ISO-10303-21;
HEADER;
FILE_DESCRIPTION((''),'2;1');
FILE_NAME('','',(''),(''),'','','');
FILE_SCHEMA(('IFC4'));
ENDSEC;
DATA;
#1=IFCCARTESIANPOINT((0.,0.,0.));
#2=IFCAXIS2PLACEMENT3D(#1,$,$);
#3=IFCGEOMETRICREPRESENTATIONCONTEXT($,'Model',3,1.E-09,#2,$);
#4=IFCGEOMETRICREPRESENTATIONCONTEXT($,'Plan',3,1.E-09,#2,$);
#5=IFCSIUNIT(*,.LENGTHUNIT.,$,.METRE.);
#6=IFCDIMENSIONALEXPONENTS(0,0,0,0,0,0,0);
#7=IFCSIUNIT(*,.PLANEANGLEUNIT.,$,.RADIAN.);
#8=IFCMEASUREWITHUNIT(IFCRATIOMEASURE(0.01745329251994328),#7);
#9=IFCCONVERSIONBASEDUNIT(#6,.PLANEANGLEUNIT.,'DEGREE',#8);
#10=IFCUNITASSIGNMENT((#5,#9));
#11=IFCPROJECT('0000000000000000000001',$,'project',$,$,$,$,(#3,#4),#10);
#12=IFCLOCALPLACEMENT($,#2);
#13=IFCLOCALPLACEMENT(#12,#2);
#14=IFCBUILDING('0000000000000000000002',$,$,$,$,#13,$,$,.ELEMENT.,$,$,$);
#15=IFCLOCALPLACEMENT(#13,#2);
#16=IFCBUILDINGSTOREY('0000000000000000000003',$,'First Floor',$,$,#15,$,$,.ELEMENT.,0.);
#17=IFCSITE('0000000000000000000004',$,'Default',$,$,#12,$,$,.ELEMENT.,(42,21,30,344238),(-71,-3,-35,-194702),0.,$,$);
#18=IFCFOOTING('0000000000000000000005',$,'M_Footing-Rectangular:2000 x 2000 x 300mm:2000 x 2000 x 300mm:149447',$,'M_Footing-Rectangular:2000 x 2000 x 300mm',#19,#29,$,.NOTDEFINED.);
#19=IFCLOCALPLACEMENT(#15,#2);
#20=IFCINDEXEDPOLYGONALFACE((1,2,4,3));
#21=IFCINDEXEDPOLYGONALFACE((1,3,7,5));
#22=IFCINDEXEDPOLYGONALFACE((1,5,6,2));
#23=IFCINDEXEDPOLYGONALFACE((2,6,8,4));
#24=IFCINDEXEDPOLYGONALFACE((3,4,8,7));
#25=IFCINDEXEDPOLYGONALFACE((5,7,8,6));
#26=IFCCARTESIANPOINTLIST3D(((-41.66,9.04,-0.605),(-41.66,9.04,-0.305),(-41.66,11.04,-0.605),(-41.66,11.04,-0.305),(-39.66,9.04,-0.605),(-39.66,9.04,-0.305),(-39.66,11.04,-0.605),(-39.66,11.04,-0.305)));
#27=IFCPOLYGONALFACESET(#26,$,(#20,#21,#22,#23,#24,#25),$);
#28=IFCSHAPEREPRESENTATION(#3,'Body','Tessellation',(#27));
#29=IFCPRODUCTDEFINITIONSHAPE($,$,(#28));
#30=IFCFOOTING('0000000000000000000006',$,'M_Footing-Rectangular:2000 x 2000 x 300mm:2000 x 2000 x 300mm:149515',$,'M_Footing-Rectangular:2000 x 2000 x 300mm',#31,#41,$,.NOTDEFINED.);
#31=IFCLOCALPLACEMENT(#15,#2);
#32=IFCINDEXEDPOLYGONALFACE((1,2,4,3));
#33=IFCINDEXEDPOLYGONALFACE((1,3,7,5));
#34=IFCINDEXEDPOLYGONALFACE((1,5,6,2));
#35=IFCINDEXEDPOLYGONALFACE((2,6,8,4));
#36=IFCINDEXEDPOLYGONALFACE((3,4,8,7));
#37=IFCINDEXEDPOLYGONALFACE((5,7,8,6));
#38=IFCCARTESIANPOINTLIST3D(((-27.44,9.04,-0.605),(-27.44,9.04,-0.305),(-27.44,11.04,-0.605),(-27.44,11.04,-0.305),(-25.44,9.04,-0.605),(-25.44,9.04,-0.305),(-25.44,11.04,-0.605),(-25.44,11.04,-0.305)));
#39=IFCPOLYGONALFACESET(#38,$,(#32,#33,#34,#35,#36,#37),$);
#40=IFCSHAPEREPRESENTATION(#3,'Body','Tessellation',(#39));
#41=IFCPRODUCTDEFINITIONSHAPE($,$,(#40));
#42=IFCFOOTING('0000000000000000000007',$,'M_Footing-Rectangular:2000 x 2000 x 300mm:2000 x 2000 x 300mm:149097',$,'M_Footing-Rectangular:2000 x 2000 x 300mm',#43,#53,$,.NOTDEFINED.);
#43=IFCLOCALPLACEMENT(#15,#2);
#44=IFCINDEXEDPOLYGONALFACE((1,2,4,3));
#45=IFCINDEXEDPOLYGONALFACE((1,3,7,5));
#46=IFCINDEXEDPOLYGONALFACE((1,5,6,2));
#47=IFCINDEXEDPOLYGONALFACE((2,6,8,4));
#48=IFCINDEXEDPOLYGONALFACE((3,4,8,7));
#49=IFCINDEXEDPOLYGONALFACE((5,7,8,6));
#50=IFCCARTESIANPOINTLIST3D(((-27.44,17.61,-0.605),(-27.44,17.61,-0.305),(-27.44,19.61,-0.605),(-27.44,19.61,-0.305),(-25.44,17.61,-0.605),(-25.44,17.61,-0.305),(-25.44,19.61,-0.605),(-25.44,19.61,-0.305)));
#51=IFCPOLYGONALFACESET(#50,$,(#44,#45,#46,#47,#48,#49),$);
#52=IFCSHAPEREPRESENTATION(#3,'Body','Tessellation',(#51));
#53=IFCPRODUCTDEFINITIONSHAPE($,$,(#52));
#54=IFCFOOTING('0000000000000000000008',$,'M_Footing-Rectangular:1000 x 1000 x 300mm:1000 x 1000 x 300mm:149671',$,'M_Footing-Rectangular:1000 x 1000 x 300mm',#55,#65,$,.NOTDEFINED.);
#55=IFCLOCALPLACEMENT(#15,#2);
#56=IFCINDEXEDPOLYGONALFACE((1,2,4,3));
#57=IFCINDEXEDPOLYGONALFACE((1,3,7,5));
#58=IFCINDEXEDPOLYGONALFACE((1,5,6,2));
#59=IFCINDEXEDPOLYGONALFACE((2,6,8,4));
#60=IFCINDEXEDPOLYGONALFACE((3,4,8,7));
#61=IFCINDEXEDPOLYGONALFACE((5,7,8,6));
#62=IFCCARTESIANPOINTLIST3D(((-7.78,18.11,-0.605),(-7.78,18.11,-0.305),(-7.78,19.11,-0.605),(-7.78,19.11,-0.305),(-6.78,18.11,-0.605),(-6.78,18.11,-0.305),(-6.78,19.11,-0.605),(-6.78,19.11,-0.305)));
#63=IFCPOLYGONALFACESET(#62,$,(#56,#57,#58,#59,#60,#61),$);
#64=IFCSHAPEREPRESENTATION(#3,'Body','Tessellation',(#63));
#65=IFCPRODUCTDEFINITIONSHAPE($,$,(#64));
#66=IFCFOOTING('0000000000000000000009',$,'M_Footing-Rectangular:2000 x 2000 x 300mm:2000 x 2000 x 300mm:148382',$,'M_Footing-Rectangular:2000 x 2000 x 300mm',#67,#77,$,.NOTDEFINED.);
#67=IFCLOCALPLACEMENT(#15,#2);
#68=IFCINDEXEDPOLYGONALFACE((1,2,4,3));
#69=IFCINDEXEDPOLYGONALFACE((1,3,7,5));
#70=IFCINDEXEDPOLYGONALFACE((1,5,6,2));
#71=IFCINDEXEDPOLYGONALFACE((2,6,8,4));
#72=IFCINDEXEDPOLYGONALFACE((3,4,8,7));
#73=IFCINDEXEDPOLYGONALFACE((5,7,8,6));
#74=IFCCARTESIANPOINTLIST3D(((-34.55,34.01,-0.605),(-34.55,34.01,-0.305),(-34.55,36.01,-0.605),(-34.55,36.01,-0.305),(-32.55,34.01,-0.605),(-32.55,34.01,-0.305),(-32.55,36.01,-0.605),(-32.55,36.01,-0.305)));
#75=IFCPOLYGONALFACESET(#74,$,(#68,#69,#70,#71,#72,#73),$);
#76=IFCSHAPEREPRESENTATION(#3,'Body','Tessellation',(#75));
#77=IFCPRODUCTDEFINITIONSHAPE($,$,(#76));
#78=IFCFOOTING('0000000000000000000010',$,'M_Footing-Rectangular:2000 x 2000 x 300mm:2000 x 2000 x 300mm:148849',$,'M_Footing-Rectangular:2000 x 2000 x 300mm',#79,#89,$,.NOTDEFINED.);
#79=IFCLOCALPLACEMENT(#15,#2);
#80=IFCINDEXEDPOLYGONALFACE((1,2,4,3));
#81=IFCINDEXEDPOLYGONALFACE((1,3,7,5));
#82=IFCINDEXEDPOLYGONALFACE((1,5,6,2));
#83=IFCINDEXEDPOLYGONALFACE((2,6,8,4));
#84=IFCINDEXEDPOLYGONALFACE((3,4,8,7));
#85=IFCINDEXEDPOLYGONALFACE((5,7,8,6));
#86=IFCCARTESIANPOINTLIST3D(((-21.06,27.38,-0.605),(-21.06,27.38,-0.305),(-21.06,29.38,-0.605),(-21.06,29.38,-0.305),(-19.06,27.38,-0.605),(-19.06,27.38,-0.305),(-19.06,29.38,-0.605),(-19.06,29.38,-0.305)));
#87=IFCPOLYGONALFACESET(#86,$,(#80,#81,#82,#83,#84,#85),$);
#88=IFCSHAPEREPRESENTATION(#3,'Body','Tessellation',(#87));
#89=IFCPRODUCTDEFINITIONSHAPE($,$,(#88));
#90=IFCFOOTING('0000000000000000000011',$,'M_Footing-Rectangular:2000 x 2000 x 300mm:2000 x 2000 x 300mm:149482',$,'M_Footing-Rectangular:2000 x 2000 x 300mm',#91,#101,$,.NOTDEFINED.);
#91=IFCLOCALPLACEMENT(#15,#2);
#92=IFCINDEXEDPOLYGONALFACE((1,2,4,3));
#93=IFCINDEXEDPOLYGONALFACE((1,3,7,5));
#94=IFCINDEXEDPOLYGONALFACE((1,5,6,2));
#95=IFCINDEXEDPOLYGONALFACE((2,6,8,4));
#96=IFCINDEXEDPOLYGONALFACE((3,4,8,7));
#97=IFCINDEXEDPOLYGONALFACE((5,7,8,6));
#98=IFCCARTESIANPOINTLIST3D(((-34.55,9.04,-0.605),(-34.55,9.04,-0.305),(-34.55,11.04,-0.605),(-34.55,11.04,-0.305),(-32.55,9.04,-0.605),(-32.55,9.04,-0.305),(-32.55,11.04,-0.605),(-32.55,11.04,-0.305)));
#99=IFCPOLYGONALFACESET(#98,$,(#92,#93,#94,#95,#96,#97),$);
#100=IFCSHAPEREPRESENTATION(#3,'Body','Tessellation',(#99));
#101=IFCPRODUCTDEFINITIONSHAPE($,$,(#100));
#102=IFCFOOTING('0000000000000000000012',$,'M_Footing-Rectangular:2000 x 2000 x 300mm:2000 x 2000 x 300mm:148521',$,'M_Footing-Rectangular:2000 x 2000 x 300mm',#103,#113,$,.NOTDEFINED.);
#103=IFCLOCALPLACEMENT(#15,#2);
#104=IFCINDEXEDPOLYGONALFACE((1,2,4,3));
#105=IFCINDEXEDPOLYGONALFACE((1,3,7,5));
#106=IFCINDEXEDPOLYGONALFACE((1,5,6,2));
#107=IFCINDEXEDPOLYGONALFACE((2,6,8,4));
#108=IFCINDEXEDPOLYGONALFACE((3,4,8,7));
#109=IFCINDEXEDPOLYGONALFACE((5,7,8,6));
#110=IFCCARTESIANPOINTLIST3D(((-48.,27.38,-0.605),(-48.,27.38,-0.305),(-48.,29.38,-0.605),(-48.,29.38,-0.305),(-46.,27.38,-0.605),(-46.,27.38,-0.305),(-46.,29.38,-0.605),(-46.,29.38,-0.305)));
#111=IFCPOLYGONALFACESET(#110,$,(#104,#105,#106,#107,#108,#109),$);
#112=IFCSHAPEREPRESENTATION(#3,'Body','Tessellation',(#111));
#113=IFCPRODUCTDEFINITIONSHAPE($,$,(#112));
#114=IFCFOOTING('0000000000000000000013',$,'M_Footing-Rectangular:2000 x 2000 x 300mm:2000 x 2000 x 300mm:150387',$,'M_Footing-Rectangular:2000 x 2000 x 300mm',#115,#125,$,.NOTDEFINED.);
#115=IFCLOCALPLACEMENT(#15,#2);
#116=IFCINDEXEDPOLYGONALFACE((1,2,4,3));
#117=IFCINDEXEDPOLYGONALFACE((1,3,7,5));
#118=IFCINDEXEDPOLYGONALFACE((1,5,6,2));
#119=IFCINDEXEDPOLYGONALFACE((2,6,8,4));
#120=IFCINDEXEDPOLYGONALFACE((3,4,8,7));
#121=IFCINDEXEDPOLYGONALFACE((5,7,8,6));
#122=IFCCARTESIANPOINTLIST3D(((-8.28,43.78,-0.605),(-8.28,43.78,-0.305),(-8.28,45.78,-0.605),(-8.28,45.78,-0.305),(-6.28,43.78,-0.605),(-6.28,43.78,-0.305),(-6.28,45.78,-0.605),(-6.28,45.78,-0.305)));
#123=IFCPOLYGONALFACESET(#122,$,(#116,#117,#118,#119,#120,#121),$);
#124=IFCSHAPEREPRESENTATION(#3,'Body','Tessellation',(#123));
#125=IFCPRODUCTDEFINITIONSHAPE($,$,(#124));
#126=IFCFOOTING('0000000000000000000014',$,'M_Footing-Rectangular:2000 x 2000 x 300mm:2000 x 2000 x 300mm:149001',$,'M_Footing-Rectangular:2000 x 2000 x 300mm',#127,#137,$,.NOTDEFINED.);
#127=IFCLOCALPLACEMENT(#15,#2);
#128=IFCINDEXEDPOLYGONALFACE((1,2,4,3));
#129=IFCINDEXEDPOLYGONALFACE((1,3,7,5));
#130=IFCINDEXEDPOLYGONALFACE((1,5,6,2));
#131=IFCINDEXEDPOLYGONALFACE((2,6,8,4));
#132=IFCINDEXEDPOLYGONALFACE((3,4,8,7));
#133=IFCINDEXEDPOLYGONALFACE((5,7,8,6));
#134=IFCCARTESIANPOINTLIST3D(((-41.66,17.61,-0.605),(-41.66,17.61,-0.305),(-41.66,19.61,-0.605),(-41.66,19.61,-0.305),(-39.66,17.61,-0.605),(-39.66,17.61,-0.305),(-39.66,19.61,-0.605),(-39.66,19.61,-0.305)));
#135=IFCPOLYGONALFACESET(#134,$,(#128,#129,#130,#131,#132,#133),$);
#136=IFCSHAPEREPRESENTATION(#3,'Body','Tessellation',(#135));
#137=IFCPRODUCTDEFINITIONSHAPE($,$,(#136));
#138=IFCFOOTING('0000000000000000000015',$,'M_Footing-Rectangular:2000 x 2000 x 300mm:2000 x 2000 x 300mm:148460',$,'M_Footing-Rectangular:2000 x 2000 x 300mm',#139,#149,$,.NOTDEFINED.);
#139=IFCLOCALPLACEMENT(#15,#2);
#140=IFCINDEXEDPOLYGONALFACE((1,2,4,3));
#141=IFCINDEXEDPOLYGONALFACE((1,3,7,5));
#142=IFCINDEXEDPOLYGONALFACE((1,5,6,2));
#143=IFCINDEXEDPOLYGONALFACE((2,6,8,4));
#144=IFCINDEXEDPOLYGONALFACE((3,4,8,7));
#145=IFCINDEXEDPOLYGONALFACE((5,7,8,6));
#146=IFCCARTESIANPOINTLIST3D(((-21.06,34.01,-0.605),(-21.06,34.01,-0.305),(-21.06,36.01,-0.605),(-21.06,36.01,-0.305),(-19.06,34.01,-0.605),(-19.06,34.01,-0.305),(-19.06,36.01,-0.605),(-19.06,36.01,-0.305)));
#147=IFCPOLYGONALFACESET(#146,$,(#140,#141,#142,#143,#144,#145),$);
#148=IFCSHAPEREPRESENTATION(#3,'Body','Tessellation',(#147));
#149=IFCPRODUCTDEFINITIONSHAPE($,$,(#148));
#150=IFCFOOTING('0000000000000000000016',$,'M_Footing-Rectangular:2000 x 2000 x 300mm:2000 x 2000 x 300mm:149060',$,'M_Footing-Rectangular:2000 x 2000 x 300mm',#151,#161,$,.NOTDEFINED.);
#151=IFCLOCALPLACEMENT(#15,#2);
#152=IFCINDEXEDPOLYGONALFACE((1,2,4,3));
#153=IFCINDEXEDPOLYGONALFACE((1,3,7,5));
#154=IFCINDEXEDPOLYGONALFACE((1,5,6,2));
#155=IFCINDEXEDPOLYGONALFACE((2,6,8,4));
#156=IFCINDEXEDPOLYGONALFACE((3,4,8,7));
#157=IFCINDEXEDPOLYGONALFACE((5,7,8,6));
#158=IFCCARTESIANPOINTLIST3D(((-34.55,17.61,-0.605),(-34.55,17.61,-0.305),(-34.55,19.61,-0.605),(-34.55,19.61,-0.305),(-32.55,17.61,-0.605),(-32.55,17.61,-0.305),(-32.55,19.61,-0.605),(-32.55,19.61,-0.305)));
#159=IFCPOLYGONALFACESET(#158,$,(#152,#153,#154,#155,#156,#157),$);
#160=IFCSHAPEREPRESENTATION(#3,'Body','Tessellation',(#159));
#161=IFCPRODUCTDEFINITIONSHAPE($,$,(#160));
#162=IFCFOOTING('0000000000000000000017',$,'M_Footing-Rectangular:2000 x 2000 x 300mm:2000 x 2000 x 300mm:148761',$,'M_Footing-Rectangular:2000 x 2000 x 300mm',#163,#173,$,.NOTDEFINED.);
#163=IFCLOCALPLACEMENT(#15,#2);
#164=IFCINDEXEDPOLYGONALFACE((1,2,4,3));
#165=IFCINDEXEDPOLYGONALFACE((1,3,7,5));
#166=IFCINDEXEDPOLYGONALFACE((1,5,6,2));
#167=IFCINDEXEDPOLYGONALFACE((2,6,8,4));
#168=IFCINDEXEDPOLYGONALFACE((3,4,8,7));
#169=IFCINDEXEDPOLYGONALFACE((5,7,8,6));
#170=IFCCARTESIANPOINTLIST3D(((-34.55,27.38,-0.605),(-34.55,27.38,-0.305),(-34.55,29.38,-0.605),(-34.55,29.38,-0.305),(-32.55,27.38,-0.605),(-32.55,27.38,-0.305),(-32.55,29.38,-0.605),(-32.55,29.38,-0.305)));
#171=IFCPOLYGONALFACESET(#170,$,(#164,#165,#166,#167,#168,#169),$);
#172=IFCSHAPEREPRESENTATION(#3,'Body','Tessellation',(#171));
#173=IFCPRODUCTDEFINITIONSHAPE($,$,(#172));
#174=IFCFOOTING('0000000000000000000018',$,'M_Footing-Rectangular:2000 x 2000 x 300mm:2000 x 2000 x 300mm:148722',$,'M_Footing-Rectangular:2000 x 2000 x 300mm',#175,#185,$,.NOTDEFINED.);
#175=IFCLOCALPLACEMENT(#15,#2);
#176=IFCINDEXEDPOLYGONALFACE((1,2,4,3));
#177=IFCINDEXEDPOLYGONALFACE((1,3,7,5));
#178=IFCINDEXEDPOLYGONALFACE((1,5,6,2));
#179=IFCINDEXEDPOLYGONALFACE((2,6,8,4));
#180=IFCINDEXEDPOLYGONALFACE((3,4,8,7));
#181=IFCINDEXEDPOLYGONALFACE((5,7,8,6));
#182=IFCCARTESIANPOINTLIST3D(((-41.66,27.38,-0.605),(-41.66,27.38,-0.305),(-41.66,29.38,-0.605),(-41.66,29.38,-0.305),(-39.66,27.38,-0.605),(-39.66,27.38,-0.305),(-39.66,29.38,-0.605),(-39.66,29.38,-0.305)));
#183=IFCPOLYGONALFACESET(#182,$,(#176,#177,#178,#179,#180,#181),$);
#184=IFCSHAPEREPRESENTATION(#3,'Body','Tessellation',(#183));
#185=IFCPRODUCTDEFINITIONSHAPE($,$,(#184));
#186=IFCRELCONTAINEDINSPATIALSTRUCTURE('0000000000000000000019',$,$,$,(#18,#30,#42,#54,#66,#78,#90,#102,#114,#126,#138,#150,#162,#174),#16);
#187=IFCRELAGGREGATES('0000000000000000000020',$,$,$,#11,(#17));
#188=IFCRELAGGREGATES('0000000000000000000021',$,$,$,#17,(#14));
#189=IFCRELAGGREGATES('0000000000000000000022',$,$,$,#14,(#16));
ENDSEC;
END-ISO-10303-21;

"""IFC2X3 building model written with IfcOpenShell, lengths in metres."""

from ifc_helpers import new_model, entity, si_unit, converted_unit, frame, origin, origin_2d_with_axis, place, context, project, spatial, rectangle, extrude, element, save


model = new_model("IFC2X3")

# Units and contexts
model_context = context("Model", 3, precision=1e-09, world=origin())
plan_context = context("Plan", 3, precision=1e-09, world=origin())
ifc_project = project(units=[si_unit("LENGTHUNIT", "METRE"), converted_unit("PLANEANGLEUNIT", "DEGREE", entity("IfcRatioMeasure", 0.01745329251994328), si_unit("PLANEANGLEUNIT", "RADIAN"), dimensions=[0, 0, 0, 0, 0, 0, 0])], contexts=[model_context, plan_context])

# Site, building, storey
site_placement = place(None, origin())
site = spatial("IfcSite", under=ifc_project, at=site_placement, Name="Default", CompositionType="ELEMENT", RefLatitude=(42, 21, 30, 344238), RefLongitude=(-71, -3, -35, -194702), RefElevation=0.0)
building_placement = place(site_placement, origin())
building = spatial("IfcBuilding", under=site, at=building_placement, CompositionType="ELEMENT")
storey_placement = place(building_placement, origin())
storey = spatial("IfcBuildingStorey", under=building, at=storey_placement, Name="First Floor", CompositionType="ELEMENT", Elevation=0.0)

# Footings
footing_1_placement = place(storey_placement, origin())
element("IfcFooting", 1, at=footing_1_placement, inside=storey, Name="M_Footing-Rectangular:2000 x 2000 x 300mm:2000 x 2000 x 300mm:149447", ObjectType="M_Footing-Rectangular:2000 x 2000 x 300mm", PredefinedType="NOTDEFINED", context=model_context, shape_type="SweptSolid", body=[
    extrude(rectangle(XDim=2.0, YDim=2.0, at=origin_2d_with_axis()), frame((-40.66, 10.04, -0.605), z_axis=(0.0, 0.0, 1.0), x_axis=(-1.0, 0.0, 0.0)), (0.0, 0.0, 1.0), 0.3),
])
footing_2_placement = place(storey_placement, origin())
element("IfcFooting", 2, at=footing_2_placement, inside=storey, Name="M_Footing-Rectangular:2000 x 2000 x 300mm:2000 x 2000 x 300mm:149515", ObjectType="M_Footing-Rectangular:2000 x 2000 x 300mm", PredefinedType="NOTDEFINED", context=model_context, shape_type="SweptSolid", body=[
    extrude(rectangle(XDim=2.0, YDim=2.0, at=origin_2d_with_axis()), frame((-26.44, 10.04, -0.605), z_axis=(0.0, 0.0, 1.0), x_axis=(-1.0, 0.0, 0.0)), (0.0, 0.0, 1.0), 0.3),
])
footing_3_placement = place(storey_placement, origin())
element("IfcFooting", 3, at=footing_3_placement, inside=storey, Name="M_Footing-Rectangular:2000 x 2000 x 300mm:2000 x 2000 x 300mm:149097", ObjectType="M_Footing-Rectangular:2000 x 2000 x 300mm", PredefinedType="NOTDEFINED", context=model_context, shape_type="SweptSolid", body=[
    extrude(rectangle(XDim=2.0, YDim=2.0, at=origin_2d_with_axis()), frame((-26.44, 18.61, -0.605), z_axis=(0.0, 0.0, 1.0), x_axis=(-1.0, 0.0, 0.0)), (0.0, 0.0, 1.0), 0.3),
])
footing_4_placement = place(storey_placement, origin())
element("IfcFooting", 4, at=footing_4_placement, inside=storey, Name="M_Footing-Rectangular:1000 x 1000 x 300mm:1000 x 1000 x 300mm:149671", ObjectType="M_Footing-Rectangular:1000 x 1000 x 300mm", PredefinedType="NOTDEFINED", context=model_context, shape_type="SweptSolid", body=[
    extrude(rectangle(XDim=1.0, YDim=1.0, at=origin_2d_with_axis()), frame((-7.28, 18.61, -0.605), z_axis=(0.0, 0.0, 1.0), x_axis=(-1.0, 0.0, 0.0)), (0.0, 0.0, 1.0), 0.3),
])
footing_5_placement = place(storey_placement, origin())
element("IfcFooting", 5, at=footing_5_placement, inside=storey, Name="M_Footing-Rectangular:2000 x 2000 x 300mm:2000 x 2000 x 300mm:148382", ObjectType="M_Footing-Rectangular:2000 x 2000 x 300mm", PredefinedType="NOTDEFINED", context=model_context, shape_type="SweptSolid", body=[
    extrude(rectangle(XDim=2.0, YDim=2.0, at=origin_2d_with_axis()), frame((-33.55, 35.01, -0.605), z_axis=(0.0, 0.0, 1.0), x_axis=(-1.0, 0.0, 0.0)), (0.0, 0.0, 1.0), 0.3),
])
footing_6_placement = place(storey_placement, origin())
element("IfcFooting", 6, at=footing_6_placement, inside=storey, Name="M_Footing-Rectangular:2000 x 2000 x 300mm:2000 x 2000 x 300mm:148849", ObjectType="M_Footing-Rectangular:2000 x 2000 x 300mm", PredefinedType="NOTDEFINED", context=model_context, shape_type="SweptSolid", body=[
    extrude(rectangle(XDim=2.0, YDim=2.0, at=origin_2d_with_axis()), frame((-20.06, 28.38, -0.605), z_axis=(0.0, 0.0, 1.0), x_axis=(-1.0, 0.0, 0.0)), (0.0, 0.0, 1.0), 0.3),
])
footing_7_placement = place(storey_placement, origin())
element("IfcFooting", 7, at=footing_7_placement, inside=storey, Name="M_Footing-Rectangular:2000 x 2000 x 300mm:2000 x 2000 x 300mm:149482", ObjectType="M_Footing-Rectangular:2000 x 2000 x 300mm", PredefinedType="NOTDEFINED", context=model_context, shape_type="SweptSolid", body=[
    extrude(rectangle(XDim=2.0, YDim=2.0, at=origin_2d_with_axis()), frame((-33.55, 10.04, -0.605), z_axis=(0.0, 0.0, 1.0), x_axis=(-1.0, 0.0, 0.0)), (0.0, 0.0, 1.0), 0.3),
])
footing_8_placement = place(storey_placement, origin())
element("IfcFooting", 8, at=footing_8_placement, inside=storey, Name="M_Footing-Rectangular:2000 x 2000 x 300mm:2000 x 2000 x 300mm:148521", ObjectType="M_Footing-Rectangular:2000 x 2000 x 300mm", PredefinedType="NOTDEFINED", context=model_context, shape_type="SweptSolid", body=[
    extrude(rectangle(XDim=2.0, YDim=2.0, at=origin_2d_with_axis()), frame((-47.0, 28.38, -0.605), z_axis=(0.0, 0.0, 1.0), x_axis=(-1.0, 0.0, 0.0)), (0.0, 0.0, 1.0), 0.3),
])
footing_9_placement = place(storey_placement, origin())
element("IfcFooting", 9, at=footing_9_placement, inside=storey, Name="M_Footing-Rectangular:2000 x 2000 x 300mm:2000 x 2000 x 300mm:150387", ObjectType="M_Footing-Rectangular:2000 x 2000 x 300mm", PredefinedType="NOTDEFINED", context=model_context, shape_type="SweptSolid", body=[
    extrude(rectangle(XDim=2.0, YDim=2.0, at=origin_2d_with_axis()), frame((-7.28, 44.78, -0.605), z_axis=(0.0, 0.0, 1.0), x_axis=(-1.0, 0.0, 0.0)), (0.0, 0.0, 1.0), 0.3),
])
footing_10_placement = place(storey_placement, origin())
element("IfcFooting", 10, at=footing_10_placement, inside=storey, Name="M_Footing-Rectangular:2000 x 2000 x 300mm:2000 x 2000 x 300mm:149001", ObjectType="M_Footing-Rectangular:2000 x 2000 x 300mm", PredefinedType="NOTDEFINED", context=model_context, shape_type="SweptSolid", body=[
    extrude(rectangle(XDim=2.0, YDim=2.0, at=origin_2d_with_axis()), frame((-40.66, 18.61, -0.605), z_axis=(0.0, 0.0, 1.0), x_axis=(-1.0, 0.0, 0.0)), (0.0, 0.0, 1.0), 0.3),
])
footing_11_placement = place(storey_placement, origin())
element("IfcFooting", 11, at=footing_11_placement, inside=storey, Name="M_Footing-Rectangular:2000 x 2000 x 300mm:2000 x 2000 x 300mm:148460", ObjectType="M_Footing-Rectangular:2000 x 2000 x 300mm", PredefinedType="NOTDEFINED", context=model_context, shape_type="SweptSolid", body=[
    extrude(rectangle(XDim=2.0, YDim=2.0, at=origin_2d_with_axis()), frame((-20.06, 35.01, -0.605), z_axis=(0.0, 0.0, 1.0), x_axis=(-1.0, 0.0, 0.0)), (0.0, 0.0, 1.0), 0.3),
])
footing_12_placement = place(storey_placement, origin())
element("IfcFooting", 12, at=footing_12_placement, inside=storey, Name="M_Footing-Rectangular:2000 x 2000 x 300mm:2000 x 2000 x 300mm:149060", ObjectType="M_Footing-Rectangular:2000 x 2000 x 300mm", PredefinedType="NOTDEFINED", context=model_context, shape_type="SweptSolid", body=[
    extrude(rectangle(XDim=2.0, YDim=2.0, at=origin_2d_with_axis()), frame((-33.55, 18.61, -0.605), z_axis=(0.0, 0.0, 1.0), x_axis=(-1.0, 0.0, 0.0)), (0.0, 0.0, 1.0), 0.3),
])
footing_13_placement = place(storey_placement, origin())
element("IfcFooting", 13, at=footing_13_placement, inside=storey, Name="M_Footing-Rectangular:2000 x 2000 x 300mm:2000 x 2000 x 300mm:148761", ObjectType="M_Footing-Rectangular:2000 x 2000 x 300mm", PredefinedType="NOTDEFINED", context=model_context, shape_type="SweptSolid", body=[
    extrude(rectangle(XDim=2.0, YDim=2.0, at=origin_2d_with_axis()), frame((-33.55, 28.38, -0.605), z_axis=(0.0, 0.0, 1.0), x_axis=(-1.0, 0.0, 0.0)), (0.0, 0.0, 1.0), 0.3),
])
footing_14_placement = place(storey_placement, origin())
element("IfcFooting", 14, at=footing_14_placement, inside=storey, Name="M_Footing-Rectangular:2000 x 2000 x 300mm:2000 x 2000 x 300mm:148722", ObjectType="M_Footing-Rectangular:2000 x 2000 x 300mm", PredefinedType="NOTDEFINED", context=model_context, shape_type="SweptSolid", body=[
    extrude(rectangle(XDim=2.0, YDim=2.0, at=origin_2d_with_axis()), frame((-40.66, 28.38, -0.605), z_axis=(0.0, 0.0, 1.0), x_axis=(-1.0, 0.0, 0.0)), (0.0, 0.0, 1.0), 0.3),
])

save(model, "model.ifc")
